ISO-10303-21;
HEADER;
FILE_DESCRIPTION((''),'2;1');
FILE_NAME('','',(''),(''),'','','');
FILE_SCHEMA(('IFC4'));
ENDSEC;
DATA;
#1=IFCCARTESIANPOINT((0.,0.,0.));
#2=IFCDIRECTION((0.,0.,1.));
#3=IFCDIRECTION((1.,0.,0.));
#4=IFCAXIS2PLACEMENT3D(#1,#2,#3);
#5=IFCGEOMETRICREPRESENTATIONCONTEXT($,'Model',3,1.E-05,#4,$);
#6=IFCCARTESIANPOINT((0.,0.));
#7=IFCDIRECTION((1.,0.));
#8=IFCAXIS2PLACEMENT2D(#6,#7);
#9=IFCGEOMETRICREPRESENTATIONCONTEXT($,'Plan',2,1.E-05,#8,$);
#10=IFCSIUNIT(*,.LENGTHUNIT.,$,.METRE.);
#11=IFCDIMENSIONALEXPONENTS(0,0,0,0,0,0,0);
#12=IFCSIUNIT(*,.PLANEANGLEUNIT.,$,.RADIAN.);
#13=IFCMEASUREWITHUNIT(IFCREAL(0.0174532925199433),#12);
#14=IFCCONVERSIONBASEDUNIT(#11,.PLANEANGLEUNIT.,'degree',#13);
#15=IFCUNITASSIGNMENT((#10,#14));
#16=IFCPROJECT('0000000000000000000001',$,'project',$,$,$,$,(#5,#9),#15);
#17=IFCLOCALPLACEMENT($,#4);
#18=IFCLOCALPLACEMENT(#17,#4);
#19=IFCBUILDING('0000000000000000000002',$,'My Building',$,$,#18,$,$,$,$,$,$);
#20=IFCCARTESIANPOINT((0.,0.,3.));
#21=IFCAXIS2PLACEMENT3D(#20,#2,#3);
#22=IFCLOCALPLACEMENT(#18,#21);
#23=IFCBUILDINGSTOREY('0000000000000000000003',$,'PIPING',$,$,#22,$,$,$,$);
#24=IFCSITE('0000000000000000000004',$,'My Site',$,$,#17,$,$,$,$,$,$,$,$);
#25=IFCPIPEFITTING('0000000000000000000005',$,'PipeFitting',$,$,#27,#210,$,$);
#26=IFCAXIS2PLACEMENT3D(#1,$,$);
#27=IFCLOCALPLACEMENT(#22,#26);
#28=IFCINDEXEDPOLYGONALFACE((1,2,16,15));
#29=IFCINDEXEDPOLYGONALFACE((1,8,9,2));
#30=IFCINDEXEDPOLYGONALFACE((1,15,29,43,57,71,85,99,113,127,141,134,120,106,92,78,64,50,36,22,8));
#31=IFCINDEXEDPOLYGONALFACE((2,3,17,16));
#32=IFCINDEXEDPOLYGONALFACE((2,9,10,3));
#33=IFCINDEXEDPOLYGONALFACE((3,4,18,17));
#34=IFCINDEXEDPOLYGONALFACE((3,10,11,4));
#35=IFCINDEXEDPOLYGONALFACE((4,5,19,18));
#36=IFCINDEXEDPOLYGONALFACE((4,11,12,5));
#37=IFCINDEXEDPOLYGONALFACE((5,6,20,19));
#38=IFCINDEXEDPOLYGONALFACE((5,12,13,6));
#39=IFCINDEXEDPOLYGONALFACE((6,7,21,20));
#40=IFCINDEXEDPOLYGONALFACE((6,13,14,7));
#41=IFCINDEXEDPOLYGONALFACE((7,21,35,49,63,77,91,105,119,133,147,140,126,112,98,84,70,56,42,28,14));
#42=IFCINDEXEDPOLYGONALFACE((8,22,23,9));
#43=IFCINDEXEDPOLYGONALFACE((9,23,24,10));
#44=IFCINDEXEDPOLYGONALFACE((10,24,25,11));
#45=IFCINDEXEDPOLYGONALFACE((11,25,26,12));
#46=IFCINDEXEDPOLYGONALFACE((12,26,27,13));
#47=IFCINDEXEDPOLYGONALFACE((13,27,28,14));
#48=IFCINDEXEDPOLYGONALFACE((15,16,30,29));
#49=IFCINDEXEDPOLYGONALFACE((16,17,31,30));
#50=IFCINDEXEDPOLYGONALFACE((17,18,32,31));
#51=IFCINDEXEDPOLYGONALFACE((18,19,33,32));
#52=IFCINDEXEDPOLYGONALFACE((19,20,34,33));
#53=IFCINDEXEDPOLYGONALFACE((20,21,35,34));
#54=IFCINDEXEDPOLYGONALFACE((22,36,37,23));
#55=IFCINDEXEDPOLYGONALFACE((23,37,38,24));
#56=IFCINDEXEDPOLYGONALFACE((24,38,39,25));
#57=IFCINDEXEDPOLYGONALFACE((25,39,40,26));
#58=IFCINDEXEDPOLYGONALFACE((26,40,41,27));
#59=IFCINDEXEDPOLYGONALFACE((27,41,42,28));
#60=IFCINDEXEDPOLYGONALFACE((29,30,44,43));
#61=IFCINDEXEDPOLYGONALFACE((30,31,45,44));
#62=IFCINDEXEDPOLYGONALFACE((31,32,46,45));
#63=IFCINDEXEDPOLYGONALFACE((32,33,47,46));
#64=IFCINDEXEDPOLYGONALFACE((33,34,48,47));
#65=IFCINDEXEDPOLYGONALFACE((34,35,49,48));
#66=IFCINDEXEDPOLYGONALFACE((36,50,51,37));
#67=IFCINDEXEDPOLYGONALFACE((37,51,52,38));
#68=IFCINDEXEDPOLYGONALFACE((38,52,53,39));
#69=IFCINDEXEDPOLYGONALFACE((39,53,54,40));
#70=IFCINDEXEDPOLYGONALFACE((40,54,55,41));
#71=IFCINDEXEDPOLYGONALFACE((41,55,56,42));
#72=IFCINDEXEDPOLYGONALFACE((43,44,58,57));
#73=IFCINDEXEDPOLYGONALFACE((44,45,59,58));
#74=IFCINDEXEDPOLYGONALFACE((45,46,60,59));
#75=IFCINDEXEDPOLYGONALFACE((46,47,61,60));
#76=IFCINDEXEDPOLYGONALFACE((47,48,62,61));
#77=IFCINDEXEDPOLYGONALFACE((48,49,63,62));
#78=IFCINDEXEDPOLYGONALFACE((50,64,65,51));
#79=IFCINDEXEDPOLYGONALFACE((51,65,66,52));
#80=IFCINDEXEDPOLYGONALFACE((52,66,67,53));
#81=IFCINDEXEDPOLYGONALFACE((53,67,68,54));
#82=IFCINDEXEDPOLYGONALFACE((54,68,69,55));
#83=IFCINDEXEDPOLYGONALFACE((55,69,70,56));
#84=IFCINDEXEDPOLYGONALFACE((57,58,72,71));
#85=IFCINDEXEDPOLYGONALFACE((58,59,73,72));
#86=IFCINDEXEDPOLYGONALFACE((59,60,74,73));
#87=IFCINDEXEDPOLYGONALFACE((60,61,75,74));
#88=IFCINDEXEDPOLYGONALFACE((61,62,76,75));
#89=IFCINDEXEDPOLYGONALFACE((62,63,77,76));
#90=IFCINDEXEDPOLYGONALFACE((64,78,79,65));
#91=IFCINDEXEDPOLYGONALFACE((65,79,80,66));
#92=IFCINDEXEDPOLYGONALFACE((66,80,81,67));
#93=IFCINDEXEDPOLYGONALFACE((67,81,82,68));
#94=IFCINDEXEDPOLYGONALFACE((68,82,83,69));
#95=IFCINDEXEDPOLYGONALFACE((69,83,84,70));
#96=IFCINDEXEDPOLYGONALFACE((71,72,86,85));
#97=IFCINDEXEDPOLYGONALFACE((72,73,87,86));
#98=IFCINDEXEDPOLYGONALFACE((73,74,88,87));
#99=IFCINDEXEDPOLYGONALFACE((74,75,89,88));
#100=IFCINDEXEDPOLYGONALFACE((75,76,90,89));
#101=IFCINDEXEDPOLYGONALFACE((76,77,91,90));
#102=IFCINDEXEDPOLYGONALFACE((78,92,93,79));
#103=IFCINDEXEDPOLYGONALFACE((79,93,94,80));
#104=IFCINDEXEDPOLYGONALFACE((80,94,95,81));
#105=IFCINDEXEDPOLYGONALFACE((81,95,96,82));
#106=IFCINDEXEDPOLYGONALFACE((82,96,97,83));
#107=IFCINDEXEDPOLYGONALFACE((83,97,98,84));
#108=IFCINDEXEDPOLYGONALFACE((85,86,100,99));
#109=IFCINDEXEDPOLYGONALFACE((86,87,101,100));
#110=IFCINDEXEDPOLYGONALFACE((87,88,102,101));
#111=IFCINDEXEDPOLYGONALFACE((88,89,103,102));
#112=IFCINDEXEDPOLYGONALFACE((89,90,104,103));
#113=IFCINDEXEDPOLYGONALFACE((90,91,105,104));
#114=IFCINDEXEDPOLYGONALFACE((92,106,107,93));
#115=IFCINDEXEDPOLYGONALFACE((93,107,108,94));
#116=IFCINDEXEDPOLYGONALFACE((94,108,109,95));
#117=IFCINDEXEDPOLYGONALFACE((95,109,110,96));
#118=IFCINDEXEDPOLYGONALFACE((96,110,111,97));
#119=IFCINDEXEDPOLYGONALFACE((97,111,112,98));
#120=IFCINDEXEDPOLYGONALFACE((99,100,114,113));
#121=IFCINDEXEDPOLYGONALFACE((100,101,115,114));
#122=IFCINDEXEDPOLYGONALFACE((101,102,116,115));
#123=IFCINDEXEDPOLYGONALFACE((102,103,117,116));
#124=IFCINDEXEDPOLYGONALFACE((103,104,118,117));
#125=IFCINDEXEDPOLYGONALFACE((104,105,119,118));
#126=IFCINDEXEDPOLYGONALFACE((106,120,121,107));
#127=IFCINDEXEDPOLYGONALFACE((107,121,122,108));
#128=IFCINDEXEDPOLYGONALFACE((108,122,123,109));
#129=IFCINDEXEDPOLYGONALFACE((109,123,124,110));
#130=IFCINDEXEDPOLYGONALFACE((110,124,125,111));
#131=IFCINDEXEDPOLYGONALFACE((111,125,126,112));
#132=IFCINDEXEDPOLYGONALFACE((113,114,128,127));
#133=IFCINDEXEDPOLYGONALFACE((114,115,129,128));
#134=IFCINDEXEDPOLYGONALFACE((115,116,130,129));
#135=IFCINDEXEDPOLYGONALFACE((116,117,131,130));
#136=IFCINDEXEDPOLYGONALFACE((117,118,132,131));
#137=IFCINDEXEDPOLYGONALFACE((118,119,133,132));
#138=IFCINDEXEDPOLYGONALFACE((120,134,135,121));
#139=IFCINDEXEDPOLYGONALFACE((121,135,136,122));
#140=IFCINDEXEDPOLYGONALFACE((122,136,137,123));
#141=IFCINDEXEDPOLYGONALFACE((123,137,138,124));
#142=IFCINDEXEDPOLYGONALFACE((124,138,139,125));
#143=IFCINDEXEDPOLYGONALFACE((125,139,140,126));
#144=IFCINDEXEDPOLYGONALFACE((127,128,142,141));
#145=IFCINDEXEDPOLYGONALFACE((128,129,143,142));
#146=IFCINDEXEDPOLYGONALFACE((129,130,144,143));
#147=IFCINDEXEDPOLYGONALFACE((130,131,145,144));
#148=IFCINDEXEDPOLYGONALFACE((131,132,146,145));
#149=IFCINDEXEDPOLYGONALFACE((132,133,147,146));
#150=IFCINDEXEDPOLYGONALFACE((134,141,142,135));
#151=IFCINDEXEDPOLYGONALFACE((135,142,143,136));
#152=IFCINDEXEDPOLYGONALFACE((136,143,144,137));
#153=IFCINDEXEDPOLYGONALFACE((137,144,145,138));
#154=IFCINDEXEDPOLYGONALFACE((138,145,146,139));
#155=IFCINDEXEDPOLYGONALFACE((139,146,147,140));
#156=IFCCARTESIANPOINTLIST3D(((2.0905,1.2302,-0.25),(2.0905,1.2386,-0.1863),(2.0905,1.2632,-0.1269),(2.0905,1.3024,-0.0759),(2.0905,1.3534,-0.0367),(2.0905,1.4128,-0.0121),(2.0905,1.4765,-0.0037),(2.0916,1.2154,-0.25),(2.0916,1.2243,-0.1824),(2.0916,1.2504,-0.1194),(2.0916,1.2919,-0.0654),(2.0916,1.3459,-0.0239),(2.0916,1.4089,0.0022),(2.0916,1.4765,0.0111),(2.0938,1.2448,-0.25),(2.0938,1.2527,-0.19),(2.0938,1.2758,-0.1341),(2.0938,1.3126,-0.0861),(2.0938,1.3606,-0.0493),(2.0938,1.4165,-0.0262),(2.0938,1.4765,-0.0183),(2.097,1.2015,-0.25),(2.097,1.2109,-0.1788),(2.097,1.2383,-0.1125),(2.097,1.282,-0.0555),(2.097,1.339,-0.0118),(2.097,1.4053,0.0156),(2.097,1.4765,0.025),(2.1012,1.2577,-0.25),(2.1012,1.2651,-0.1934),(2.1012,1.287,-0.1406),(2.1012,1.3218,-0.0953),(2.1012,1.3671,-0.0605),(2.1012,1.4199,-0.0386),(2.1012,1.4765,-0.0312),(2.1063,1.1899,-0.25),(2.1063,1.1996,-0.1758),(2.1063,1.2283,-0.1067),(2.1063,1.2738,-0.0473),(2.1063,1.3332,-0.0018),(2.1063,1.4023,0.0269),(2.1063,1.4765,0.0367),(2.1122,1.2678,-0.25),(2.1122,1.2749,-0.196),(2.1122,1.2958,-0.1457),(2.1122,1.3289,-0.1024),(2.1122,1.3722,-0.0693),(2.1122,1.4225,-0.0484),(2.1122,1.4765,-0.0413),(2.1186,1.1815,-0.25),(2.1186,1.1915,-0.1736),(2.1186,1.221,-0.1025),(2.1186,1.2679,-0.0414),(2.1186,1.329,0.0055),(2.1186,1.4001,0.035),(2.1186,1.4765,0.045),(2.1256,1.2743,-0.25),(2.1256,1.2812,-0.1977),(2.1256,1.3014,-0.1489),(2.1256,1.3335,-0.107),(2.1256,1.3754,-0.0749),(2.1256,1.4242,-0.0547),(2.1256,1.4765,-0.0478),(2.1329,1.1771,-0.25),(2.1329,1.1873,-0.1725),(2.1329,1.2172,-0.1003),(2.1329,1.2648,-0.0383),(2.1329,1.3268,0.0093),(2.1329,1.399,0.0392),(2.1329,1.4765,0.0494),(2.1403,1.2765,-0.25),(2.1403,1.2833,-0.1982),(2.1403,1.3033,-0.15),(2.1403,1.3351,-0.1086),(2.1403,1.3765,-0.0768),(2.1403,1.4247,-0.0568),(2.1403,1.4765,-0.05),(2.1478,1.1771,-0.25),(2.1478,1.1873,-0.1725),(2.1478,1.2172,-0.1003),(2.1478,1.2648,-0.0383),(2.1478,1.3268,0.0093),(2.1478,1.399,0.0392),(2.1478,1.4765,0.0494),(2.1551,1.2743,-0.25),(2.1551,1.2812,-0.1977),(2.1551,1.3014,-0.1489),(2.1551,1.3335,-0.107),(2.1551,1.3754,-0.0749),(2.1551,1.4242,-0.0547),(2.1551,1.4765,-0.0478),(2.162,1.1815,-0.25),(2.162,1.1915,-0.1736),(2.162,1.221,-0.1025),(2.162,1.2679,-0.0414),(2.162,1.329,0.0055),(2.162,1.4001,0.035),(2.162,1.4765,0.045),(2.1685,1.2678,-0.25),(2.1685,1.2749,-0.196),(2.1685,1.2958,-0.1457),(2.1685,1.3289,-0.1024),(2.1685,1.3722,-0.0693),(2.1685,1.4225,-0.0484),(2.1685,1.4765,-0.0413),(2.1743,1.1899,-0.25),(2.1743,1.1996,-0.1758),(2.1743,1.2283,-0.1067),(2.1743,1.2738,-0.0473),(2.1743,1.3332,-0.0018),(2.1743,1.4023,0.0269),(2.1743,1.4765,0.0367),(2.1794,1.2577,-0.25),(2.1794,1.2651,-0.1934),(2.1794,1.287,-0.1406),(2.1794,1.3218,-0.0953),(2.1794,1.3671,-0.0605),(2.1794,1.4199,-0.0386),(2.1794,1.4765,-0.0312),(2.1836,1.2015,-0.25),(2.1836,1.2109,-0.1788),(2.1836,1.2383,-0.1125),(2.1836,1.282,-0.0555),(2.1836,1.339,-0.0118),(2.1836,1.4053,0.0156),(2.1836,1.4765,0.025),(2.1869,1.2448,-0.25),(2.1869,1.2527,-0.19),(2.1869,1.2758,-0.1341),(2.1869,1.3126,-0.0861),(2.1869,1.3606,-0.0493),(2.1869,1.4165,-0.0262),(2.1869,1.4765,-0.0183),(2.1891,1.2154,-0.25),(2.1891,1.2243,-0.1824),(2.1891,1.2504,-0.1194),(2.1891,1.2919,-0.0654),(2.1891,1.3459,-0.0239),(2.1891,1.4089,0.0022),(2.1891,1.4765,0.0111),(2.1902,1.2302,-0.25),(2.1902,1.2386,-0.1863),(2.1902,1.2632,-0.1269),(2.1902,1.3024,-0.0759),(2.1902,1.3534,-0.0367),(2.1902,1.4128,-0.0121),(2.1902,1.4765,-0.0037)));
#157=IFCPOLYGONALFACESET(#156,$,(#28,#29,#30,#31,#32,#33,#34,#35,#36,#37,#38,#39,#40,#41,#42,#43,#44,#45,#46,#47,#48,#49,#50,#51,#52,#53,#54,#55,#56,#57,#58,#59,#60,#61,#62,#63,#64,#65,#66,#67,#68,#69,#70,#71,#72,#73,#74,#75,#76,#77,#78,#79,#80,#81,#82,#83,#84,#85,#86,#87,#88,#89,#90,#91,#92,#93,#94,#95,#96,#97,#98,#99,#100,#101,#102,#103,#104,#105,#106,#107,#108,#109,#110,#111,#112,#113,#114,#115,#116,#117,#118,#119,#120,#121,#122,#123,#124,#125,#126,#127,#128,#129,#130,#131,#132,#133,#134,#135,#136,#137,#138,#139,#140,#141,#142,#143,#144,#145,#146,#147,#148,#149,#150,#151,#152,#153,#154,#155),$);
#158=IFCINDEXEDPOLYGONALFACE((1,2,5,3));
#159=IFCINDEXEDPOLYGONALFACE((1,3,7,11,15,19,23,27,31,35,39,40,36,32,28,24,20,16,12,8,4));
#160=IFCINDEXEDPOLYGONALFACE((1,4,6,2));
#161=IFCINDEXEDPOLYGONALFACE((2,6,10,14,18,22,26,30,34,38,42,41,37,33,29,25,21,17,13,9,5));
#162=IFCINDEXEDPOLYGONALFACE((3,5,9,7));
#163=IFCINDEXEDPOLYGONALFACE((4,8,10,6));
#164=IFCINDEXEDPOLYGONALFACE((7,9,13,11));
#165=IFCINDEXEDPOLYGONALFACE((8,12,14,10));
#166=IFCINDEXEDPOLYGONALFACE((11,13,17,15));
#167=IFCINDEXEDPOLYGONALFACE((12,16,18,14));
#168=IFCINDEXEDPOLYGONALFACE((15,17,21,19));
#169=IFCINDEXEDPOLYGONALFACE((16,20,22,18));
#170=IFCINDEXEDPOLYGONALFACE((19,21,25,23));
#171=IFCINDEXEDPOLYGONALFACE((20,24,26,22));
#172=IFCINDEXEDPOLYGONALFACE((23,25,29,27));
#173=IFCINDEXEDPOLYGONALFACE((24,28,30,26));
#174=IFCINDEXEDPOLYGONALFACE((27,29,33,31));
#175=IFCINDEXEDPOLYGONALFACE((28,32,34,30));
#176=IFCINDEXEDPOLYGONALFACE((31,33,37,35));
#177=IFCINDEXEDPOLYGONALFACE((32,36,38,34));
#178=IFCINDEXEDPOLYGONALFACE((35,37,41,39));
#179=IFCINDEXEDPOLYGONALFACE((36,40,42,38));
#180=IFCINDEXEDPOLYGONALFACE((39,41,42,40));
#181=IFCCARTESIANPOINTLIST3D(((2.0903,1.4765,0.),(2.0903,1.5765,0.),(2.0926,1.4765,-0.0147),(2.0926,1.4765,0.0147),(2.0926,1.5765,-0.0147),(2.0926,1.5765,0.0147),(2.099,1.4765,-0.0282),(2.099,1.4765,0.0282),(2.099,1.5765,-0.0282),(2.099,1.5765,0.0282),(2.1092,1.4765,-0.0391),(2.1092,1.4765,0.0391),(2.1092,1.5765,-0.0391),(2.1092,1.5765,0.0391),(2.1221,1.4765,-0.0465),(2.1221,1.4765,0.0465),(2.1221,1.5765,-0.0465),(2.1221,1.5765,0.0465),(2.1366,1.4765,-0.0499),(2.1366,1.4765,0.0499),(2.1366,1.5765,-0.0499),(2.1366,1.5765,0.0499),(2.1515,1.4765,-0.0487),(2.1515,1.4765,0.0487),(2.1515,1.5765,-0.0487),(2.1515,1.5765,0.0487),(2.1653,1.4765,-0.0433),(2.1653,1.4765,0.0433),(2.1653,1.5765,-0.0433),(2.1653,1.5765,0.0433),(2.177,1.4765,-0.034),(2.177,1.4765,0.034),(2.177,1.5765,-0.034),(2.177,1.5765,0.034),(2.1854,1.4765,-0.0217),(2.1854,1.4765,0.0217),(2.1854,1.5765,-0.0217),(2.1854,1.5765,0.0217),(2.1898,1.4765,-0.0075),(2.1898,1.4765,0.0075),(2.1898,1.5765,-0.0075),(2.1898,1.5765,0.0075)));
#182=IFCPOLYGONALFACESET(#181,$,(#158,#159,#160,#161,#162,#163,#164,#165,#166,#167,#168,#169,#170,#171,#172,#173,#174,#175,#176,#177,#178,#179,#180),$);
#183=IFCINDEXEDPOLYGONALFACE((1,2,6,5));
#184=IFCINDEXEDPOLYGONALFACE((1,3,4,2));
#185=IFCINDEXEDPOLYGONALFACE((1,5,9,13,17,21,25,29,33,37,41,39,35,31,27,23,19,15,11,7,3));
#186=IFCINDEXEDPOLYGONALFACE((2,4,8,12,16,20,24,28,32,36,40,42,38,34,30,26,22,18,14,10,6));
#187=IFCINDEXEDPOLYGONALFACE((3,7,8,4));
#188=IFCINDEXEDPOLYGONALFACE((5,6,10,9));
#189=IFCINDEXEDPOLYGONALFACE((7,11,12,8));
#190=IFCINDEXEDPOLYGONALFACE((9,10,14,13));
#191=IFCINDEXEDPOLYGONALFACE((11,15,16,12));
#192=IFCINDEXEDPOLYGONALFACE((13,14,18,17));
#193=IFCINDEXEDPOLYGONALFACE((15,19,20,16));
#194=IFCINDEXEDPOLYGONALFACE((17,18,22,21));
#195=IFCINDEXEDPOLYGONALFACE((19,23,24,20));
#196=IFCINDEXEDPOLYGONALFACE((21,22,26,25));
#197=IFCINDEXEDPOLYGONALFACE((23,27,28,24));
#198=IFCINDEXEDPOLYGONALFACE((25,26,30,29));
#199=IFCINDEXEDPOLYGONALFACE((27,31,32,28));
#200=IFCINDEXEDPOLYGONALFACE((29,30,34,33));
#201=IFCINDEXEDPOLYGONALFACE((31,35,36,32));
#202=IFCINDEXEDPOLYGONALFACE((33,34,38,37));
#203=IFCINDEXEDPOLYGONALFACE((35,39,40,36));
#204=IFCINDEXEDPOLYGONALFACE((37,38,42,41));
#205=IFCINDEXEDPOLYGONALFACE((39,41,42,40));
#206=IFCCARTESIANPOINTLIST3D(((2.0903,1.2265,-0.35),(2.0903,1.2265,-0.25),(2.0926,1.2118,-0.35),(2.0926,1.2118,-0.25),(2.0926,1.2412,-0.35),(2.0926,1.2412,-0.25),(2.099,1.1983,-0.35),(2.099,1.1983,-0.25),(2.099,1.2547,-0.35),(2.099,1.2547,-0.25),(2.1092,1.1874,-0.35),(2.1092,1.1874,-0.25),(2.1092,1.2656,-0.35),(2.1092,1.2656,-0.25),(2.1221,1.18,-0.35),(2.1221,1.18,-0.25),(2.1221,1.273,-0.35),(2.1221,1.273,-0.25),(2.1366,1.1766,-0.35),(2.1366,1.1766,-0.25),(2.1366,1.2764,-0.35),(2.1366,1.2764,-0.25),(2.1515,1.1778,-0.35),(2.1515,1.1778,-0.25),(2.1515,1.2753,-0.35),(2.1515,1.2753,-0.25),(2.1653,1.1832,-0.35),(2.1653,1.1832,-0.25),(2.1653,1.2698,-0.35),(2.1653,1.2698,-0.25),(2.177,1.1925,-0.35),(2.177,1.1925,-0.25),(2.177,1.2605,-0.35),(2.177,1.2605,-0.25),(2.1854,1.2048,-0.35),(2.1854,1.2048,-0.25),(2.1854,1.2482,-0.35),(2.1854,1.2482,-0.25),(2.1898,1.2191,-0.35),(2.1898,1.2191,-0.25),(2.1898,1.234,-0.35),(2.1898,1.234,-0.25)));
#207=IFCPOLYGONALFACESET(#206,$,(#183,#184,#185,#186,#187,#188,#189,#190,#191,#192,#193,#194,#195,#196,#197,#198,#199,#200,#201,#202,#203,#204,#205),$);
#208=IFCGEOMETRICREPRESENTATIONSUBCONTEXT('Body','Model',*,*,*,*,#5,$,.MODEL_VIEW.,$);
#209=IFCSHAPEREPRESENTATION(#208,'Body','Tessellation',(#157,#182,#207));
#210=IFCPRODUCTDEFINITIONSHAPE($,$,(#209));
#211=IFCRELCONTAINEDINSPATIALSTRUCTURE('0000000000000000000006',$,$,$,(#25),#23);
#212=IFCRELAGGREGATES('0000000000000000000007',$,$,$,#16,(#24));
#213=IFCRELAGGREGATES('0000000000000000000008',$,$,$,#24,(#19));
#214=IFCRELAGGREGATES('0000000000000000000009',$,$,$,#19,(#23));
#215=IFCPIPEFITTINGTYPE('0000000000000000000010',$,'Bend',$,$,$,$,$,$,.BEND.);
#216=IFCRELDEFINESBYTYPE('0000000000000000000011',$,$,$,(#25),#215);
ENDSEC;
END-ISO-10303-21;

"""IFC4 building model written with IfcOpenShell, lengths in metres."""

from ifc_helpers import new_model, entity, si_unit, converted_unit, frame, origin_with_axes, origin_2d_with_axis, place, context, subcontext, project, spatial, circle, extrude, source, transform, mapped, type_object, type_shapes, element, save


model = new_model("IFC4")

# Units and contexts
model_context = context("Model", 3, precision=1e-05, world=origin_with_axes())
plan_context = context("Plan", 2, precision=1e-05, world=origin_2d_with_axis())
body_context = subcontext(model_context, "Body", "Model", "MODEL_VIEW")
ifc_project = project(units=[si_unit("LENGTHUNIT", "METRE"), converted_unit("PLANEANGLEUNIT", "degree", entity("IfcReal", 0.0174532925199433), si_unit("PLANEANGLEUNIT", "RADIAN"), dimensions=[0, 0, 0, 0, 0, 0, 0])], contexts=[model_context, plan_context])

# Site, building, storey
site_placement = place(None, origin_with_axes())
site = spatial("IfcSite", under=ifc_project, at=site_placement, Name="My Site")
building_placement = place(site_placement, origin_with_axes())
building = spatial("IfcBuilding", under=site, at=building_placement, Name="My Building")
storey_placement = place(building_placement, frame((0.0, 0.0, 3.0), z_axis=(0.0, 0.0, 1.0), x_axis=(1.0, 0.0, 0.0)))
storey = spatial("IfcBuildingStorey", under=building, at=storey_placement, Name="PIPING")

# Pipe fitting
pipe_fitting_type = type_object("IfcPipeFittingType", Name="Bend", PredefinedType="BEND")
shared_shape = source(origin_with_axes(), body_context, "Body", "SolidModel", [
    entity("IfcSweptDiskSolid", entity("IfcIndexedPolyCurve", entity("IfcCartesianPointList3D", [[0.0, 0.0, -0.1], [0.0, -0.0732, -0.2768], [0.0, -0.25, -0.35]]), [entity("IfcArcIndex", [1, 2, 3])]), 0.05),
    extrude(circle(Radius=0.05), origin_with_axes(), (0.0, 0.0, -1.0), 0.1),
    extrude(circle(Radius=0.05), frame((0.0, -0.25, -0.35), z_axis=(0.0, -1.0, 0.0), x_axis=(1.0, 0.0, 0.0)), (0.0, 0.0, 1.0), 0.1),
])
type_shapes(pipe_fitting_type, [shared_shape])
for number, where, z_axis, x_axis, name in (
    (1, (2.1403, 1.5765, 0.0), (0.0, 1.0, 0.0), (-1.0, 0.0, 0.0), "PipeFitting"),
):
    element("IfcPipeFitting", number, at=place(storey_placement, frame(where, z_axis=z_axis, x_axis=x_axis)), inside=storey, type_object=pipe_fitting_type, Name=name, context=body_context, shape_type="MappedRepresentation", body=[
        mapped(shared_shape, transform((0.0, 0.0, 0.0), x_axis=(1.0, 0.0, 0.0), y_axis=(0.0, 1.0, 0.0), z_axis=(0.0, 0.0, 1.0), scale=1.0)),
    ])

save(model, "model.ifc")
